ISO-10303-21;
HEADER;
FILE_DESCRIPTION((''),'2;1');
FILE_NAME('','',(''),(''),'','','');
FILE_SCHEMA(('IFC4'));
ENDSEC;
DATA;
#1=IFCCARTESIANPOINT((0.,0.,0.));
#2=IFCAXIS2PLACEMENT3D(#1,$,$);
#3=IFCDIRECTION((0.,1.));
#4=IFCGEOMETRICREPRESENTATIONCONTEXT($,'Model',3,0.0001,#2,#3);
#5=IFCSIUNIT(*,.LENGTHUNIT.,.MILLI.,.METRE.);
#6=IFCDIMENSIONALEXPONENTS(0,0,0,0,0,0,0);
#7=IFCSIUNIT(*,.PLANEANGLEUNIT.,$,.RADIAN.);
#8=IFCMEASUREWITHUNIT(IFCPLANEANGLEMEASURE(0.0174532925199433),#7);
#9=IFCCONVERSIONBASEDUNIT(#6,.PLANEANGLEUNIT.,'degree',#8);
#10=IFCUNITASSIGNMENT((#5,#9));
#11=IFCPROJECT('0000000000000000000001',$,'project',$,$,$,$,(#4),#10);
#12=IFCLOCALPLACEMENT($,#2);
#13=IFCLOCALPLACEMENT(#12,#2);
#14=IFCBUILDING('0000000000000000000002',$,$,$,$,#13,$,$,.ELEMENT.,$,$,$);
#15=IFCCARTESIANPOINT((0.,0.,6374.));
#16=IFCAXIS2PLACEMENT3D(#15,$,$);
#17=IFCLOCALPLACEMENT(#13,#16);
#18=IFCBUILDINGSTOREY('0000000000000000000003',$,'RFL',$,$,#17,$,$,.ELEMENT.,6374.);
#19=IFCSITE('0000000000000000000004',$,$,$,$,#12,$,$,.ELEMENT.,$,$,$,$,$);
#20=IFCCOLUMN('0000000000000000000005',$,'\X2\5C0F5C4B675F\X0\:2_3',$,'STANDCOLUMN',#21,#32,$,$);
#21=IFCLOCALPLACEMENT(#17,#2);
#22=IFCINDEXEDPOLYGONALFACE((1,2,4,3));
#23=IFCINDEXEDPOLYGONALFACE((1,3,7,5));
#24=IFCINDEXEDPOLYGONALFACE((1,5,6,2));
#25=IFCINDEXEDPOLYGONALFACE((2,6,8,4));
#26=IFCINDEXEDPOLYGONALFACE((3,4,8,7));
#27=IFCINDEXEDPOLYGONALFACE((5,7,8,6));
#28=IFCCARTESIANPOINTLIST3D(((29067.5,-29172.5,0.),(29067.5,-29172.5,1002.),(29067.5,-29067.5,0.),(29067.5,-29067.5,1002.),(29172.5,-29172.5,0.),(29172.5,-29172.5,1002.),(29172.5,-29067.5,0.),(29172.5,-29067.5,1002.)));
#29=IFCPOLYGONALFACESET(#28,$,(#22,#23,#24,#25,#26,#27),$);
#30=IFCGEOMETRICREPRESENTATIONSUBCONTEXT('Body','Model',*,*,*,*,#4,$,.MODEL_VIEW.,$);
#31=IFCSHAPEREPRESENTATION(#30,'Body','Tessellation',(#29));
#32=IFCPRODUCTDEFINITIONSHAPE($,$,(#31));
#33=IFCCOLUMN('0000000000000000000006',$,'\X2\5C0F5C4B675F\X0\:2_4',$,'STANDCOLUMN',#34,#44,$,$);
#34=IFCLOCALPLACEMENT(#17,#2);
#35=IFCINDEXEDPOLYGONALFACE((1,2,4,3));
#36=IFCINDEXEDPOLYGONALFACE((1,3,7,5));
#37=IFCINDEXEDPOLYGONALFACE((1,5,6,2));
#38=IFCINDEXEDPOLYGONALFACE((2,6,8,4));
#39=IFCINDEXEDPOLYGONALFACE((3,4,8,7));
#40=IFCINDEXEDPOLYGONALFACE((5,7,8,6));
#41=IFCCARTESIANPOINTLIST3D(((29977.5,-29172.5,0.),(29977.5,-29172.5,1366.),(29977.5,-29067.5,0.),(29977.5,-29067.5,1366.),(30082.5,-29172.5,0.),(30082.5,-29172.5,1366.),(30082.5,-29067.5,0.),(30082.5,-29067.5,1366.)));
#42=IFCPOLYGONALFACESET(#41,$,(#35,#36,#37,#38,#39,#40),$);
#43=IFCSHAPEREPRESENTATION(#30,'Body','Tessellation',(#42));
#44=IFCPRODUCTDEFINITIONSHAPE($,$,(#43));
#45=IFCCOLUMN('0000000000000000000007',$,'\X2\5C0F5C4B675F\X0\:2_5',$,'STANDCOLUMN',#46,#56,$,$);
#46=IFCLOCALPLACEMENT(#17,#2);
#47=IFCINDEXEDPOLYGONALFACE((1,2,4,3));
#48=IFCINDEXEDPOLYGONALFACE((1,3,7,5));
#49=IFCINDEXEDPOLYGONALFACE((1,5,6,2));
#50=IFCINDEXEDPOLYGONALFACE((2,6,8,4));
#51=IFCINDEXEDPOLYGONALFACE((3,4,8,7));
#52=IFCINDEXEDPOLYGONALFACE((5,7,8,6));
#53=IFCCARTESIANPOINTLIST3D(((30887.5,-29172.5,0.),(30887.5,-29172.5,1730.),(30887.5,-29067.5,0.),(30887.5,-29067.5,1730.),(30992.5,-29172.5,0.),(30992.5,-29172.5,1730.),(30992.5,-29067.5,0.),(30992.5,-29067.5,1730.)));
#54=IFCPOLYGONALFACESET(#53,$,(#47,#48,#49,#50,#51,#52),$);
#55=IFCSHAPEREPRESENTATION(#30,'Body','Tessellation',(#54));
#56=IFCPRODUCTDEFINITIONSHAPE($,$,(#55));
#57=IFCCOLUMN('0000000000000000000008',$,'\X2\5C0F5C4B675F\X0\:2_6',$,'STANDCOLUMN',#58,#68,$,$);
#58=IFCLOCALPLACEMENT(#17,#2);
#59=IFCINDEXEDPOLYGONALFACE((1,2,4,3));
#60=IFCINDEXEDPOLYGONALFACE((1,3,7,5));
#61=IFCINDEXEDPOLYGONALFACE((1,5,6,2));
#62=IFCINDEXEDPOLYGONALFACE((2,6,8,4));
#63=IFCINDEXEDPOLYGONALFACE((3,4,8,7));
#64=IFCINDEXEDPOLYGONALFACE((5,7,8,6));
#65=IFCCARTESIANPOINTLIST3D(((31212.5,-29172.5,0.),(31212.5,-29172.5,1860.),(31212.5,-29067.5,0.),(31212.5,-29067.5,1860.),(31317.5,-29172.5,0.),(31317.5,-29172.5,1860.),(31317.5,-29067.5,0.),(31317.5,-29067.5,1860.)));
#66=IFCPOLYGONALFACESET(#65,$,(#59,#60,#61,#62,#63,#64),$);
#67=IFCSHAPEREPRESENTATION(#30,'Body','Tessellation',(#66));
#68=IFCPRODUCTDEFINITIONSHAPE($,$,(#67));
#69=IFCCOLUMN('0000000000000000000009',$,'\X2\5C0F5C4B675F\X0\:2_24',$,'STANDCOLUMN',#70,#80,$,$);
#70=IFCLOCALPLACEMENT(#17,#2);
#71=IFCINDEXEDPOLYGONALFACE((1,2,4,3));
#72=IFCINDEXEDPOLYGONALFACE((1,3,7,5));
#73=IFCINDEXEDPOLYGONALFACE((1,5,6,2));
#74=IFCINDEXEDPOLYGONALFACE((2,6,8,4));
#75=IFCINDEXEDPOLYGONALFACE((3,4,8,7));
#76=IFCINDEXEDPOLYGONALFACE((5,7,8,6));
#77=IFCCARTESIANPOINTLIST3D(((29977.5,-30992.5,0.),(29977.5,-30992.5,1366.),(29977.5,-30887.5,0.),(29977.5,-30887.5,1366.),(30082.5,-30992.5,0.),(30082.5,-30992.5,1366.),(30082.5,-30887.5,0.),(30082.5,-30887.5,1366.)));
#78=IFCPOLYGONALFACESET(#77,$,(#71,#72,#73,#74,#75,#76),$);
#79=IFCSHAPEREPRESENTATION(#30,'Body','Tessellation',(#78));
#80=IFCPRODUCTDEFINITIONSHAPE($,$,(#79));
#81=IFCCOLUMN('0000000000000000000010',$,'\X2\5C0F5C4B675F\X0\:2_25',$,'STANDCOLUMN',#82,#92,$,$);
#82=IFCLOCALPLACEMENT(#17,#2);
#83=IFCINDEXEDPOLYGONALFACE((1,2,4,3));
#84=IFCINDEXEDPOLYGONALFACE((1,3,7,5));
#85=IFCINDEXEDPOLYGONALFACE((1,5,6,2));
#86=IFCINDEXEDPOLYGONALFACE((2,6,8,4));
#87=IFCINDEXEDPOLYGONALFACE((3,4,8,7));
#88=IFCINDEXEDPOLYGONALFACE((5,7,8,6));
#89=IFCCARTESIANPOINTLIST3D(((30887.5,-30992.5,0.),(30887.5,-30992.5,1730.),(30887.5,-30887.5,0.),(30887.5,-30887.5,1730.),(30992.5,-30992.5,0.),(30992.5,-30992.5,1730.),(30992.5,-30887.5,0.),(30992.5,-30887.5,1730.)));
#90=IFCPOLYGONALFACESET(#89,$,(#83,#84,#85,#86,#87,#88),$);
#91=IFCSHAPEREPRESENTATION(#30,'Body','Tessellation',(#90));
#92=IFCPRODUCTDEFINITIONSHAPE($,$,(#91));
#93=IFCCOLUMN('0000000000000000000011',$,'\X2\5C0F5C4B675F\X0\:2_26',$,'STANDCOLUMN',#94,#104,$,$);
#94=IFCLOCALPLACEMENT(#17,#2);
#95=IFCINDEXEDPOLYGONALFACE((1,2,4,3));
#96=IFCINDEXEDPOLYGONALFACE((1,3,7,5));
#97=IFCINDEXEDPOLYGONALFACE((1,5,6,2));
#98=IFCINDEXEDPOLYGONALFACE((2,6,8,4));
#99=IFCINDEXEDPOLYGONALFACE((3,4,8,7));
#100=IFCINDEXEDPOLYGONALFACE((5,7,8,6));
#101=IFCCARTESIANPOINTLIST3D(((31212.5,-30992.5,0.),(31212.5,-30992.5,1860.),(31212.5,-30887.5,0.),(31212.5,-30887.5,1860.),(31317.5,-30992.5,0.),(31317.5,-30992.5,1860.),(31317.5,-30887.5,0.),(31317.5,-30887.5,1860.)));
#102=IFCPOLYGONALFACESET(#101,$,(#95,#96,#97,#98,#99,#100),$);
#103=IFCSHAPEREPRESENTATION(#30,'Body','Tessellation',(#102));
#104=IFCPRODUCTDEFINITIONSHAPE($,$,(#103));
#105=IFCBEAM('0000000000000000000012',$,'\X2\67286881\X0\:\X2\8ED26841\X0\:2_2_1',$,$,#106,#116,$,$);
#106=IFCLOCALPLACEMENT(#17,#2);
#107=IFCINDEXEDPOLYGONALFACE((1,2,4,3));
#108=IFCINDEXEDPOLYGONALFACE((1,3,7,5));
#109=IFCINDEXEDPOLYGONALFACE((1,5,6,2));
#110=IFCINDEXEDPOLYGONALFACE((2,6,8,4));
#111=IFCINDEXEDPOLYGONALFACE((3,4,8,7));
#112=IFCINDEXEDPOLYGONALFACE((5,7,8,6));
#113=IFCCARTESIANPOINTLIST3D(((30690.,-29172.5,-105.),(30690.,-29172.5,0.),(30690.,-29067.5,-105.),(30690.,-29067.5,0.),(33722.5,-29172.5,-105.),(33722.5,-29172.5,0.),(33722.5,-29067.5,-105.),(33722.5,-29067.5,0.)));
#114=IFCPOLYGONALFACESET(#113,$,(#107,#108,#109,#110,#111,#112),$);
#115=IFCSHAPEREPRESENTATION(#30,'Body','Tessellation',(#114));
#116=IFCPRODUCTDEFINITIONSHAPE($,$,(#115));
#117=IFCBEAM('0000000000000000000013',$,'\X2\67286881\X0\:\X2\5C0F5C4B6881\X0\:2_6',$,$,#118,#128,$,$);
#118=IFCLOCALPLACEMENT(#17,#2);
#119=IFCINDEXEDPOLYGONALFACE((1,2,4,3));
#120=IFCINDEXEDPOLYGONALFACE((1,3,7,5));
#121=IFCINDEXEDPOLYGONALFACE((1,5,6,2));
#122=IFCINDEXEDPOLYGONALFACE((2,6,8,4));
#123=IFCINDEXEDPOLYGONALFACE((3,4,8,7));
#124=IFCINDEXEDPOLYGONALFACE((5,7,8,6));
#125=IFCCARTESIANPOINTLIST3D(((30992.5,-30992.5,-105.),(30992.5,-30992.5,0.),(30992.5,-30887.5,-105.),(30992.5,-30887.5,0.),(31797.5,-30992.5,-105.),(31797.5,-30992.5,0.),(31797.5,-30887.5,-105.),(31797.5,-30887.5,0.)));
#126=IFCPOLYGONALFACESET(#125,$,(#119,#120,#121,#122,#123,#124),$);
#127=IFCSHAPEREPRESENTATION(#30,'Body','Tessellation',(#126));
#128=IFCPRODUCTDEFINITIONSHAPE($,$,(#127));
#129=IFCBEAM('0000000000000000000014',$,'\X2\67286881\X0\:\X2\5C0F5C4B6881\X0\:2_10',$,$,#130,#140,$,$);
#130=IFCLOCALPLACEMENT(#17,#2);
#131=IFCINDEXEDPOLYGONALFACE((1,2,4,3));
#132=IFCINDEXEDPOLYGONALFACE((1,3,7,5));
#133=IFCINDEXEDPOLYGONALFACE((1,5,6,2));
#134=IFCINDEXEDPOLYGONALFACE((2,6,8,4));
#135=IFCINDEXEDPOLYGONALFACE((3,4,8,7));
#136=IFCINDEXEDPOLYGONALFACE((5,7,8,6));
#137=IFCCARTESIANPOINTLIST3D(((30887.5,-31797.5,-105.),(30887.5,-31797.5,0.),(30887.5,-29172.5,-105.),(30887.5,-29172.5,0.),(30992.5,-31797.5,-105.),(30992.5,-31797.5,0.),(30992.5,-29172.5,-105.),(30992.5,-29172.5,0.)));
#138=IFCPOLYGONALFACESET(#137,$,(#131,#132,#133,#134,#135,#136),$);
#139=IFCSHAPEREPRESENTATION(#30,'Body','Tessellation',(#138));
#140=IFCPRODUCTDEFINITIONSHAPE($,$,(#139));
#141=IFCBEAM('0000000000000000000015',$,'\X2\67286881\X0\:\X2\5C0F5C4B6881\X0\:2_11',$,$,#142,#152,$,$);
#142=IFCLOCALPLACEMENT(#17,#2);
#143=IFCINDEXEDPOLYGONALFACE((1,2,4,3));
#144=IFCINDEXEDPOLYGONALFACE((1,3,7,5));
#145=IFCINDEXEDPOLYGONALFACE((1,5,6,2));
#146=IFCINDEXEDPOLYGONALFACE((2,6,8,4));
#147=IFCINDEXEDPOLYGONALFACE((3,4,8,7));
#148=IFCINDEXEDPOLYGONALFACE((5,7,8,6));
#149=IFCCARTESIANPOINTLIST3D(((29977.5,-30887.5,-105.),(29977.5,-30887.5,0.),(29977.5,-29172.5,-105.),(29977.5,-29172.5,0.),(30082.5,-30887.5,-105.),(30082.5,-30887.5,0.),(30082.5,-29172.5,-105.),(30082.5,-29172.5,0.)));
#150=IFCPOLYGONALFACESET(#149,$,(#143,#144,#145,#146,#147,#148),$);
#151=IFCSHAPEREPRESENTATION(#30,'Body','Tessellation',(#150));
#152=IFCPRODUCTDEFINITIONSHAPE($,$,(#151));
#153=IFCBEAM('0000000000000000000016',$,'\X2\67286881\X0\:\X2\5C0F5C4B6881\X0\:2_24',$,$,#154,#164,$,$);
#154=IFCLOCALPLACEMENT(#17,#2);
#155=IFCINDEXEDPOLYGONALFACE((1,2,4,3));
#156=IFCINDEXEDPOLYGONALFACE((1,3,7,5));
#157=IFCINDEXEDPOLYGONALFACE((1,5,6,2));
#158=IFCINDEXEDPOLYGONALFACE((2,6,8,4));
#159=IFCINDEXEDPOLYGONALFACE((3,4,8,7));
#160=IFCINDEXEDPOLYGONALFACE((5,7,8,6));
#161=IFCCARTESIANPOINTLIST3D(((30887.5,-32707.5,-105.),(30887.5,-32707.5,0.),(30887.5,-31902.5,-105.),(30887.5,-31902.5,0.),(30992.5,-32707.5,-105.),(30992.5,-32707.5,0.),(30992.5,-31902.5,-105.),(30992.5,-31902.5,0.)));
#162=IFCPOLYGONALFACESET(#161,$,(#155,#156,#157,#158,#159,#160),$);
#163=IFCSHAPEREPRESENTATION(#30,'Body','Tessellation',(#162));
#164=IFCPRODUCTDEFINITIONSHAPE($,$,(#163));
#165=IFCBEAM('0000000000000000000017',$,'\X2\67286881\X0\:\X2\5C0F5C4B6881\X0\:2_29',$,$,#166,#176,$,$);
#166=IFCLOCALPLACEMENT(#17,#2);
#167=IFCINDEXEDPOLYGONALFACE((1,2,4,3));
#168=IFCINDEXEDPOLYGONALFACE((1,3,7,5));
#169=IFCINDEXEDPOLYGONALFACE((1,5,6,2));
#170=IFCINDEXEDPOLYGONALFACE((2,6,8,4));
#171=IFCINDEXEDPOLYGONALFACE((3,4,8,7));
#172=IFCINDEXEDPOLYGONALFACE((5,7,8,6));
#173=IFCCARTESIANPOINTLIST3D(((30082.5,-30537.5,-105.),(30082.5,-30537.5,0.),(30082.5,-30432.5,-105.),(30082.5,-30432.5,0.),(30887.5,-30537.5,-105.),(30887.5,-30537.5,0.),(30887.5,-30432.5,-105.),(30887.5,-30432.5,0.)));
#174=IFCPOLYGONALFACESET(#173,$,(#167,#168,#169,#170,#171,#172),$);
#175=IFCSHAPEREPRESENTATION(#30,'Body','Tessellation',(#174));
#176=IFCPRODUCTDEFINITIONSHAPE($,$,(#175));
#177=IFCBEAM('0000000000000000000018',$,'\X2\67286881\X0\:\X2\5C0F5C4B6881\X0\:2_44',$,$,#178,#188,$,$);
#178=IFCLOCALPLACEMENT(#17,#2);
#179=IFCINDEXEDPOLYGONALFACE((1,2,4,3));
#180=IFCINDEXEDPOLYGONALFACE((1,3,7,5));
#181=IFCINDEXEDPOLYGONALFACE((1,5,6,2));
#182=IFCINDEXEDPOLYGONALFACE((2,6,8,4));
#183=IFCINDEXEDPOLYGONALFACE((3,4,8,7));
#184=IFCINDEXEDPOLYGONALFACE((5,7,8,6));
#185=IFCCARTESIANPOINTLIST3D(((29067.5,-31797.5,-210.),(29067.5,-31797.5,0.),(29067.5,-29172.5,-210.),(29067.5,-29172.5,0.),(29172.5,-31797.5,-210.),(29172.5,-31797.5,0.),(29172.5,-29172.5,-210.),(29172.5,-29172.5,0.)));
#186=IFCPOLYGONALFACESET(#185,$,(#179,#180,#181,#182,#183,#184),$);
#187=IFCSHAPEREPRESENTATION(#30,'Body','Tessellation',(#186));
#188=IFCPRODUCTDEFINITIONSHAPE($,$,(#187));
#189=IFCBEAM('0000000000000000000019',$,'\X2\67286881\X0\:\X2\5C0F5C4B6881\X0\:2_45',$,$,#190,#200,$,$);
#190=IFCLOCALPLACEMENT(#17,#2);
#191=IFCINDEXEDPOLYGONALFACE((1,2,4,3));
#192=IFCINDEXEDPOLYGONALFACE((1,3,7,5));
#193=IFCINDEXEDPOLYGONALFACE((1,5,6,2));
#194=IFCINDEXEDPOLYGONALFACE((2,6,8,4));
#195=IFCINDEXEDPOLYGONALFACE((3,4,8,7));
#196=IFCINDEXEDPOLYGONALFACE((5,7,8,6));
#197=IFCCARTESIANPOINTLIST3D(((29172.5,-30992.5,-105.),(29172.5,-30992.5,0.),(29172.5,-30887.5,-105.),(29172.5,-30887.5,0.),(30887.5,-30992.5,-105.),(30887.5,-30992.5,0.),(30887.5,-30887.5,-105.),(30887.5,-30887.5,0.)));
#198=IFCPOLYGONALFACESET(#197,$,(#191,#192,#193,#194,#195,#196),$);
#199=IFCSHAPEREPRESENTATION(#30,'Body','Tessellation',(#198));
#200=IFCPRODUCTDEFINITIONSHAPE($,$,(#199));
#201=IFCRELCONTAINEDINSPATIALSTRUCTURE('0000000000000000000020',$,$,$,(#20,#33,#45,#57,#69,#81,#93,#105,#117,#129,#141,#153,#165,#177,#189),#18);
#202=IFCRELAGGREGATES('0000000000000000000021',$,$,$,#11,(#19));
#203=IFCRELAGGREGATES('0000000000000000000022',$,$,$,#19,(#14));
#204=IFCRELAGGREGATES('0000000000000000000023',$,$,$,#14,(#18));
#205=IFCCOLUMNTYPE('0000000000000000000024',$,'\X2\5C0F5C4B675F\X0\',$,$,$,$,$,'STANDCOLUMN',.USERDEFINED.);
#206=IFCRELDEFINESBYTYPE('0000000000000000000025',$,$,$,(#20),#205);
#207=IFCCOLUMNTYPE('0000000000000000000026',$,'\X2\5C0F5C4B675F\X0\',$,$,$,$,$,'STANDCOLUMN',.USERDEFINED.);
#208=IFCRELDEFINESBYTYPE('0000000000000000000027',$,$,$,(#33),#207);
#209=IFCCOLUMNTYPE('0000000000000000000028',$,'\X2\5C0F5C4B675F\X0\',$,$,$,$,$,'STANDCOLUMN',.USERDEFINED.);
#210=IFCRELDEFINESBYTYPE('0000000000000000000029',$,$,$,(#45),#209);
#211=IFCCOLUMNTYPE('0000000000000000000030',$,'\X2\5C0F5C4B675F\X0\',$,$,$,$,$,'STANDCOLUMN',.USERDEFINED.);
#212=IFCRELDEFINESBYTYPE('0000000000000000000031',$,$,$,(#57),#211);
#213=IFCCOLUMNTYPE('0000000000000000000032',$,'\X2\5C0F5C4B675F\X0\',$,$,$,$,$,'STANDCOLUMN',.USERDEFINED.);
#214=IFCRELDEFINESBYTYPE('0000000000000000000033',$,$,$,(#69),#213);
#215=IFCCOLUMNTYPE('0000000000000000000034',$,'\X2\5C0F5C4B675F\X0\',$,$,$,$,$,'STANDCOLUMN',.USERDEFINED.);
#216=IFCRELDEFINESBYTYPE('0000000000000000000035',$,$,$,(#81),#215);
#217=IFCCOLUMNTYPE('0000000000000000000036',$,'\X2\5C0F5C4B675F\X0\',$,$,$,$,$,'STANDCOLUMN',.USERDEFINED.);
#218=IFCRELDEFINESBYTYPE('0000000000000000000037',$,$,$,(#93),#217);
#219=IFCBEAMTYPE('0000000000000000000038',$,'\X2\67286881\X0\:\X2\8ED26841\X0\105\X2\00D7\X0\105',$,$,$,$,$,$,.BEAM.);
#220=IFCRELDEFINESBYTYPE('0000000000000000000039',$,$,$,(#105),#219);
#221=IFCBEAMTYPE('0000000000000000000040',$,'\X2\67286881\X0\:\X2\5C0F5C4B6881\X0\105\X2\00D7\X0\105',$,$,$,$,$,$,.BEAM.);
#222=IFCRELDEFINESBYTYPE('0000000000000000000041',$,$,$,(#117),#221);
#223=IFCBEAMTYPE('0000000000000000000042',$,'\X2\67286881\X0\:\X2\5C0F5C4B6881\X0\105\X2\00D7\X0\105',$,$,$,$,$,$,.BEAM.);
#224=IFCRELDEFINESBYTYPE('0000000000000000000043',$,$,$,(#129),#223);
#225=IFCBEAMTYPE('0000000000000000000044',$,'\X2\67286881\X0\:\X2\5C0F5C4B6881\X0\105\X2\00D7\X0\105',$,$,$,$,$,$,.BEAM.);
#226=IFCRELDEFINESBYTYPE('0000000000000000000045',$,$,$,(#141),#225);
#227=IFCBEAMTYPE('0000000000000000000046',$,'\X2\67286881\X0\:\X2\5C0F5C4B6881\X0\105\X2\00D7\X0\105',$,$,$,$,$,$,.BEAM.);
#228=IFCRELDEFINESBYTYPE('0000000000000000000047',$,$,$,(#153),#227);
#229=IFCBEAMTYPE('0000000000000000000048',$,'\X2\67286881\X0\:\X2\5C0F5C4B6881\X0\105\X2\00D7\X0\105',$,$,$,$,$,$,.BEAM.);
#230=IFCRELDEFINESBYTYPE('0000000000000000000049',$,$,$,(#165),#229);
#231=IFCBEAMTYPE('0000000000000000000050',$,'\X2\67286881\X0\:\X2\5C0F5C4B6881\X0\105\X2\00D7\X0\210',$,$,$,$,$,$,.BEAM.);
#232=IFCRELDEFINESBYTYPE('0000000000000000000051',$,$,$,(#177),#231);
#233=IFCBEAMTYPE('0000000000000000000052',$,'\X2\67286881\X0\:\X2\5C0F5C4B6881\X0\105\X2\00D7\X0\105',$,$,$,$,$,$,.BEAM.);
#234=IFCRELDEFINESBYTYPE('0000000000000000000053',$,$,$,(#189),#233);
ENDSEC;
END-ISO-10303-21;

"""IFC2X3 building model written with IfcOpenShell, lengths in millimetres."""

from ifc_helpers import new_model, entity, si_unit, converted_unit, direction, frame, origin, origin_with_axes, origin_2d, place, context, subcontext, project, spatial, rectangle, extrude, type_object, element, save


model = new_model("IFC2X3")

# Units and contexts
model_context = context("Model", 3, precision=0.0001, world=origin(), true_north=direction((0.0, 1.0)))
body_context = subcontext(model_context, "Body", "Model", "MODEL_VIEW")
ifc_project = project(units=[si_unit("LENGTHUNIT", "METRE", prefix="MILLI"), converted_unit("PLANEANGLEUNIT", "degree", entity("IfcPlaneAngleMeasure", 0.0174532925199433), si_unit("PLANEANGLEUNIT", "RADIAN"), dimensions=[0, 0, 0, 0, 0, 0, 0])], contexts=[model_context])

# Site, building, storey
site_placement = place(None, origin())
site = spatial("IfcSite", under=ifc_project, at=site_placement, CompositionType="ELEMENT")
building_placement = place(site_placement, origin())
building = spatial("IfcBuilding", under=site, at=building_placement, CompositionType="ELEMENT")
storey_placement = place(building_placement, frame((0.0, 0.0, 6374.0)))
storey = spatial("IfcBuildingStorey", under=building, at=storey_placement, Name="RFL", CompositionType="ELEMENT", Elevation=6374.0)

# Columns
column_type_1 = type_object("IfcColumnType", Name="小屋束", ElementType="STANDCOLUMN", PredefinedType="USERDEFINED")
column_1_placement = place(storey_placement, frame((29120.0, -29120.0, 0.0)))
element("IfcColumn", 1, at=column_1_placement, inside=storey, type_object=column_type_1, Name="小屋束:2_3", ObjectType="STANDCOLUMN", context=body_context, shape_type="SweptSolid", body=[
    extrude(rectangle(XDim=105.0, YDim=105.0, at=origin_2d()), origin_with_axes(), (0.0, 0.0, 1.0), 1002.0),
])
column_type_2 = type_object("IfcColumnType", Name="小屋束", ElementType="STANDCOLUMN", PredefinedType="USERDEFINED")
column_2_placement = place(storey_placement, frame((30030.0, -29120.0, 0.0)))
element("IfcColumn", 2, at=column_2_placement, inside=storey, type_object=column_type_2, Name="小屋束:2_4", ObjectType="STANDCOLUMN", context=body_context, shape_type="SweptSolid", body=[
    extrude(rectangle(XDim=105.0, YDim=105.0, at=origin_2d()), origin_with_axes(), (0.0, 0.0, 1.0), 1366.0),
])
column_type_3 = type_object("IfcColumnType", Name="小屋束", ElementType="STANDCOLUMN", PredefinedType="USERDEFINED")
column_3_placement = place(storey_placement, frame((30940.0, -29120.0, 0.0)))
element("IfcColumn", 3, at=column_3_placement, inside=storey, type_object=column_type_3, Name="小屋束:2_5", ObjectType="STANDCOLUMN", context=body_context, shape_type="SweptSolid", body=[
    extrude(rectangle(XDim=105.0, YDim=105.0, at=origin_2d()), origin_with_axes(), (0.0, 0.0, 1.0), 1730.0),
])
column_type_4 = type_object("IfcColumnType", Name="小屋束", ElementType="STANDCOLUMN", PredefinedType="USERDEFINED")
column_4_placement = place(storey_placement, frame((31265.0, -29120.0, 0.0)))
element("IfcColumn", 4, at=column_4_placement, inside=storey, type_object=column_type_4, Name="小屋束:2_6", ObjectType="STANDCOLUMN", context=body_context, shape_type="SweptSolid", body=[
    extrude(rectangle(XDim=105.0, YDim=105.0, at=origin_2d()), origin_with_axes(), (0.0, 0.0, 1.0), 1860.0),
])
column_type_5 = type_object("IfcColumnType", Name="小屋束", ElementType="STANDCOLUMN", PredefinedType="USERDEFINED")
column_5_placement = place(storey_placement, frame((30030.0, -30940.0, 0.0)))
element("IfcColumn", 5, at=column_5_placement, inside=storey, type_object=column_type_5, Name="小屋束:2_24", ObjectType="STANDCOLUMN", context=body_context, shape_type="SweptSolid", body=[
    extrude(rectangle(XDim=105.0, YDim=105.0, at=origin_2d()), origin_with_axes(), (0.0, 0.0, 1.0), 1366.0),
])
column_type_6 = type_object("IfcColumnType", Name="小屋束", ElementType="STANDCOLUMN", PredefinedType="USERDEFINED")
column_6_placement = place(storey_placement, frame((30940.0, -30940.0, 0.0)))
element("IfcColumn", 6, at=column_6_placement, inside=storey, type_object=column_type_6, Name="小屋束:2_25", ObjectType="STANDCOLUMN", context=body_context, shape_type="SweptSolid", body=[
    extrude(rectangle(XDim=105.0, YDim=105.0, at=origin_2d()), origin_with_axes(), (0.0, 0.0, 1.0), 1730.0),
])
column_type_7 = type_object("IfcColumnType", Name="小屋束", ElementType="STANDCOLUMN", PredefinedType="USERDEFINED")
column_7_placement = place(storey_placement, frame((31265.0, -30940.0, 0.0)))
element("IfcColumn", 7, at=column_7_placement, inside=storey, type_object=column_type_7, Name="小屋束:2_26", ObjectType="STANDCOLUMN", context=body_context, shape_type="SweptSolid", body=[
    extrude(rectangle(XDim=105.0, YDim=105.0, at=origin_2d()), origin_with_axes(), (0.0, 0.0, 1.0), 1860.0),
])

# Beams
beam_type_1 = type_object("IfcBeamType", Name="木梁:軒桁105×105", PredefinedType="BEAM")
beam_1_placement = place(storey_placement, frame((30690.0, -29120.0, -52.5), z_axis=(1.0, 0.0, 0.0), x_axis=(0.0, 1.0, 0.0)))
element("IfcBeam", 8, at=beam_1_placement, inside=storey, type_object=beam_type_1, Name="木梁:軒桁:2_2_1", context=body_context, shape_type="SweptSolid", body=[
    extrude(rectangle(XDim=105.0, YDim=105.0, at=origin_2d()), origin_with_axes(), (0.0, 0.0, 1.0), 3032.5),
])
beam_type_2 = type_object("IfcBeamType", Name="木梁:小屋梁105×105", PredefinedType="BEAM")
beam_2_placement = place(storey_placement, frame((30992.5, -30940.0, -52.5), z_axis=(1.0, 0.0, 0.0), x_axis=(0.0, 1.0, 0.0)))
element("IfcBeam", 9, at=beam_2_placement, inside=storey, type_object=beam_type_2, Name="木梁:小屋梁:2_6", context=body_context, shape_type="SweptSolid", body=[
    extrude(rectangle(XDim=105.0, YDim=105.0, at=origin_2d()), origin_with_axes(), (0.0, 0.0, 1.0), 805.0),
])
beam_type_3 = type_object("IfcBeamType", Name="木梁:小屋梁105×105", PredefinedType="BEAM")
beam_3_placement = place(storey_placement, frame((30940.0, -29172.5, -52.5), z_axis=(0.0, -1.0, 0.0), x_axis=(1.0, 0.0, 0.0)))
element("IfcBeam", 10, at=beam_3_placement, inside=storey, type_object=beam_type_3, Name="木梁:小屋梁:2_10", context=body_context, shape_type="SweptSolid", body=[
    extrude(rectangle(XDim=105.0, YDim=105.0, at=origin_2d()), origin_with_axes(), (0.0, 0.0, 1.0), 2625.0),
])
beam_type_4 = type_object("IfcBeamType", Name="木梁:小屋梁105×105", PredefinedType="BEAM")
beam_4_placement = place(storey_placement, frame((30030.0, -29172.5, -52.5), z_axis=(0.0, -1.0, 0.0), x_axis=(1.0, 0.0, 0.0)))
element("IfcBeam", 11, at=beam_4_placement, inside=storey, type_object=beam_type_4, Name="木梁:小屋梁:2_11", context=body_context, shape_type="SweptSolid", body=[
    extrude(rectangle(XDim=105.0, YDim=105.0, at=origin_2d()), origin_with_axes(), (0.0, 0.0, 1.0), 1715.0),
])
beam_type_5 = type_object("IfcBeamType", Name="木梁:小屋梁105×105", PredefinedType="BEAM")
beam_5_placement = place(storey_placement, frame((30940.0, -31902.5, -52.5), z_axis=(0.0, -1.0, 0.0), x_axis=(1.0, 0.0, 0.0)))
element("IfcBeam", 12, at=beam_5_placement, inside=storey, type_object=beam_type_5, Name="木梁:小屋梁:2_24", context=body_context, shape_type="SweptSolid", body=[
    extrude(rectangle(XDim=105.0, YDim=105.0, at=origin_2d()), origin_with_axes(), (0.0, 0.0, 1.0), 805.0),
])
beam_type_6 = type_object("IfcBeamType", Name="木梁:小屋梁105×105", PredefinedType="BEAM")
beam_6_placement = place(storey_placement, frame((30082.5, -30485.0, -52.5), z_axis=(1.0, 0.0, 0.0), x_axis=(0.0, 1.0, 0.0)))
element("IfcBeam", 13, at=beam_6_placement, inside=storey, type_object=beam_type_6, Name="木梁:小屋梁:2_29", context=body_context, shape_type="SweptSolid", body=[
    extrude(rectangle(XDim=105.0, YDim=105.0, at=origin_2d()), origin_with_axes(), (0.0, 0.0, 1.0), 805.0),
])
beam_type_7 = type_object("IfcBeamType", Name="木梁:小屋梁105×210", PredefinedType="BEAM")
beam_7_placement = place(storey_placement, frame((29120.0, -29172.5, -105.0), z_axis=(0.0, -1.0, 0.0), x_axis=(1.0, 0.0, 0.0)))
element("IfcBeam", 14, at=beam_7_placement, inside=storey, type_object=beam_type_7, Name="木梁:小屋梁:2_44", context=body_context, shape_type="SweptSolid", body=[
    extrude(rectangle(XDim=105.0, YDim=210.0, at=origin_2d()), origin_with_axes(), (0.0, 0.0, 1.0), 2625.0),
])
beam_type_8 = type_object("IfcBeamType", Name="木梁:小屋梁105×105", PredefinedType="BEAM")
beam_8_placement = place(storey_placement, frame((29172.5, -30940.0, -52.5), z_axis=(1.0, 0.0, 0.0), x_axis=(0.0, 1.0, 0.0)))
element("IfcBeam", 15, at=beam_8_placement, inside=storey, type_object=beam_type_8, Name="木梁:小屋梁:2_45", context=body_context, shape_type="SweptSolid", body=[
    extrude(rectangle(XDim=105.0, YDim=105.0, at=origin_2d()), origin_with_axes(), (0.0, 0.0, 1.0), 1715.0),
])

save(model, "model.ifc")
